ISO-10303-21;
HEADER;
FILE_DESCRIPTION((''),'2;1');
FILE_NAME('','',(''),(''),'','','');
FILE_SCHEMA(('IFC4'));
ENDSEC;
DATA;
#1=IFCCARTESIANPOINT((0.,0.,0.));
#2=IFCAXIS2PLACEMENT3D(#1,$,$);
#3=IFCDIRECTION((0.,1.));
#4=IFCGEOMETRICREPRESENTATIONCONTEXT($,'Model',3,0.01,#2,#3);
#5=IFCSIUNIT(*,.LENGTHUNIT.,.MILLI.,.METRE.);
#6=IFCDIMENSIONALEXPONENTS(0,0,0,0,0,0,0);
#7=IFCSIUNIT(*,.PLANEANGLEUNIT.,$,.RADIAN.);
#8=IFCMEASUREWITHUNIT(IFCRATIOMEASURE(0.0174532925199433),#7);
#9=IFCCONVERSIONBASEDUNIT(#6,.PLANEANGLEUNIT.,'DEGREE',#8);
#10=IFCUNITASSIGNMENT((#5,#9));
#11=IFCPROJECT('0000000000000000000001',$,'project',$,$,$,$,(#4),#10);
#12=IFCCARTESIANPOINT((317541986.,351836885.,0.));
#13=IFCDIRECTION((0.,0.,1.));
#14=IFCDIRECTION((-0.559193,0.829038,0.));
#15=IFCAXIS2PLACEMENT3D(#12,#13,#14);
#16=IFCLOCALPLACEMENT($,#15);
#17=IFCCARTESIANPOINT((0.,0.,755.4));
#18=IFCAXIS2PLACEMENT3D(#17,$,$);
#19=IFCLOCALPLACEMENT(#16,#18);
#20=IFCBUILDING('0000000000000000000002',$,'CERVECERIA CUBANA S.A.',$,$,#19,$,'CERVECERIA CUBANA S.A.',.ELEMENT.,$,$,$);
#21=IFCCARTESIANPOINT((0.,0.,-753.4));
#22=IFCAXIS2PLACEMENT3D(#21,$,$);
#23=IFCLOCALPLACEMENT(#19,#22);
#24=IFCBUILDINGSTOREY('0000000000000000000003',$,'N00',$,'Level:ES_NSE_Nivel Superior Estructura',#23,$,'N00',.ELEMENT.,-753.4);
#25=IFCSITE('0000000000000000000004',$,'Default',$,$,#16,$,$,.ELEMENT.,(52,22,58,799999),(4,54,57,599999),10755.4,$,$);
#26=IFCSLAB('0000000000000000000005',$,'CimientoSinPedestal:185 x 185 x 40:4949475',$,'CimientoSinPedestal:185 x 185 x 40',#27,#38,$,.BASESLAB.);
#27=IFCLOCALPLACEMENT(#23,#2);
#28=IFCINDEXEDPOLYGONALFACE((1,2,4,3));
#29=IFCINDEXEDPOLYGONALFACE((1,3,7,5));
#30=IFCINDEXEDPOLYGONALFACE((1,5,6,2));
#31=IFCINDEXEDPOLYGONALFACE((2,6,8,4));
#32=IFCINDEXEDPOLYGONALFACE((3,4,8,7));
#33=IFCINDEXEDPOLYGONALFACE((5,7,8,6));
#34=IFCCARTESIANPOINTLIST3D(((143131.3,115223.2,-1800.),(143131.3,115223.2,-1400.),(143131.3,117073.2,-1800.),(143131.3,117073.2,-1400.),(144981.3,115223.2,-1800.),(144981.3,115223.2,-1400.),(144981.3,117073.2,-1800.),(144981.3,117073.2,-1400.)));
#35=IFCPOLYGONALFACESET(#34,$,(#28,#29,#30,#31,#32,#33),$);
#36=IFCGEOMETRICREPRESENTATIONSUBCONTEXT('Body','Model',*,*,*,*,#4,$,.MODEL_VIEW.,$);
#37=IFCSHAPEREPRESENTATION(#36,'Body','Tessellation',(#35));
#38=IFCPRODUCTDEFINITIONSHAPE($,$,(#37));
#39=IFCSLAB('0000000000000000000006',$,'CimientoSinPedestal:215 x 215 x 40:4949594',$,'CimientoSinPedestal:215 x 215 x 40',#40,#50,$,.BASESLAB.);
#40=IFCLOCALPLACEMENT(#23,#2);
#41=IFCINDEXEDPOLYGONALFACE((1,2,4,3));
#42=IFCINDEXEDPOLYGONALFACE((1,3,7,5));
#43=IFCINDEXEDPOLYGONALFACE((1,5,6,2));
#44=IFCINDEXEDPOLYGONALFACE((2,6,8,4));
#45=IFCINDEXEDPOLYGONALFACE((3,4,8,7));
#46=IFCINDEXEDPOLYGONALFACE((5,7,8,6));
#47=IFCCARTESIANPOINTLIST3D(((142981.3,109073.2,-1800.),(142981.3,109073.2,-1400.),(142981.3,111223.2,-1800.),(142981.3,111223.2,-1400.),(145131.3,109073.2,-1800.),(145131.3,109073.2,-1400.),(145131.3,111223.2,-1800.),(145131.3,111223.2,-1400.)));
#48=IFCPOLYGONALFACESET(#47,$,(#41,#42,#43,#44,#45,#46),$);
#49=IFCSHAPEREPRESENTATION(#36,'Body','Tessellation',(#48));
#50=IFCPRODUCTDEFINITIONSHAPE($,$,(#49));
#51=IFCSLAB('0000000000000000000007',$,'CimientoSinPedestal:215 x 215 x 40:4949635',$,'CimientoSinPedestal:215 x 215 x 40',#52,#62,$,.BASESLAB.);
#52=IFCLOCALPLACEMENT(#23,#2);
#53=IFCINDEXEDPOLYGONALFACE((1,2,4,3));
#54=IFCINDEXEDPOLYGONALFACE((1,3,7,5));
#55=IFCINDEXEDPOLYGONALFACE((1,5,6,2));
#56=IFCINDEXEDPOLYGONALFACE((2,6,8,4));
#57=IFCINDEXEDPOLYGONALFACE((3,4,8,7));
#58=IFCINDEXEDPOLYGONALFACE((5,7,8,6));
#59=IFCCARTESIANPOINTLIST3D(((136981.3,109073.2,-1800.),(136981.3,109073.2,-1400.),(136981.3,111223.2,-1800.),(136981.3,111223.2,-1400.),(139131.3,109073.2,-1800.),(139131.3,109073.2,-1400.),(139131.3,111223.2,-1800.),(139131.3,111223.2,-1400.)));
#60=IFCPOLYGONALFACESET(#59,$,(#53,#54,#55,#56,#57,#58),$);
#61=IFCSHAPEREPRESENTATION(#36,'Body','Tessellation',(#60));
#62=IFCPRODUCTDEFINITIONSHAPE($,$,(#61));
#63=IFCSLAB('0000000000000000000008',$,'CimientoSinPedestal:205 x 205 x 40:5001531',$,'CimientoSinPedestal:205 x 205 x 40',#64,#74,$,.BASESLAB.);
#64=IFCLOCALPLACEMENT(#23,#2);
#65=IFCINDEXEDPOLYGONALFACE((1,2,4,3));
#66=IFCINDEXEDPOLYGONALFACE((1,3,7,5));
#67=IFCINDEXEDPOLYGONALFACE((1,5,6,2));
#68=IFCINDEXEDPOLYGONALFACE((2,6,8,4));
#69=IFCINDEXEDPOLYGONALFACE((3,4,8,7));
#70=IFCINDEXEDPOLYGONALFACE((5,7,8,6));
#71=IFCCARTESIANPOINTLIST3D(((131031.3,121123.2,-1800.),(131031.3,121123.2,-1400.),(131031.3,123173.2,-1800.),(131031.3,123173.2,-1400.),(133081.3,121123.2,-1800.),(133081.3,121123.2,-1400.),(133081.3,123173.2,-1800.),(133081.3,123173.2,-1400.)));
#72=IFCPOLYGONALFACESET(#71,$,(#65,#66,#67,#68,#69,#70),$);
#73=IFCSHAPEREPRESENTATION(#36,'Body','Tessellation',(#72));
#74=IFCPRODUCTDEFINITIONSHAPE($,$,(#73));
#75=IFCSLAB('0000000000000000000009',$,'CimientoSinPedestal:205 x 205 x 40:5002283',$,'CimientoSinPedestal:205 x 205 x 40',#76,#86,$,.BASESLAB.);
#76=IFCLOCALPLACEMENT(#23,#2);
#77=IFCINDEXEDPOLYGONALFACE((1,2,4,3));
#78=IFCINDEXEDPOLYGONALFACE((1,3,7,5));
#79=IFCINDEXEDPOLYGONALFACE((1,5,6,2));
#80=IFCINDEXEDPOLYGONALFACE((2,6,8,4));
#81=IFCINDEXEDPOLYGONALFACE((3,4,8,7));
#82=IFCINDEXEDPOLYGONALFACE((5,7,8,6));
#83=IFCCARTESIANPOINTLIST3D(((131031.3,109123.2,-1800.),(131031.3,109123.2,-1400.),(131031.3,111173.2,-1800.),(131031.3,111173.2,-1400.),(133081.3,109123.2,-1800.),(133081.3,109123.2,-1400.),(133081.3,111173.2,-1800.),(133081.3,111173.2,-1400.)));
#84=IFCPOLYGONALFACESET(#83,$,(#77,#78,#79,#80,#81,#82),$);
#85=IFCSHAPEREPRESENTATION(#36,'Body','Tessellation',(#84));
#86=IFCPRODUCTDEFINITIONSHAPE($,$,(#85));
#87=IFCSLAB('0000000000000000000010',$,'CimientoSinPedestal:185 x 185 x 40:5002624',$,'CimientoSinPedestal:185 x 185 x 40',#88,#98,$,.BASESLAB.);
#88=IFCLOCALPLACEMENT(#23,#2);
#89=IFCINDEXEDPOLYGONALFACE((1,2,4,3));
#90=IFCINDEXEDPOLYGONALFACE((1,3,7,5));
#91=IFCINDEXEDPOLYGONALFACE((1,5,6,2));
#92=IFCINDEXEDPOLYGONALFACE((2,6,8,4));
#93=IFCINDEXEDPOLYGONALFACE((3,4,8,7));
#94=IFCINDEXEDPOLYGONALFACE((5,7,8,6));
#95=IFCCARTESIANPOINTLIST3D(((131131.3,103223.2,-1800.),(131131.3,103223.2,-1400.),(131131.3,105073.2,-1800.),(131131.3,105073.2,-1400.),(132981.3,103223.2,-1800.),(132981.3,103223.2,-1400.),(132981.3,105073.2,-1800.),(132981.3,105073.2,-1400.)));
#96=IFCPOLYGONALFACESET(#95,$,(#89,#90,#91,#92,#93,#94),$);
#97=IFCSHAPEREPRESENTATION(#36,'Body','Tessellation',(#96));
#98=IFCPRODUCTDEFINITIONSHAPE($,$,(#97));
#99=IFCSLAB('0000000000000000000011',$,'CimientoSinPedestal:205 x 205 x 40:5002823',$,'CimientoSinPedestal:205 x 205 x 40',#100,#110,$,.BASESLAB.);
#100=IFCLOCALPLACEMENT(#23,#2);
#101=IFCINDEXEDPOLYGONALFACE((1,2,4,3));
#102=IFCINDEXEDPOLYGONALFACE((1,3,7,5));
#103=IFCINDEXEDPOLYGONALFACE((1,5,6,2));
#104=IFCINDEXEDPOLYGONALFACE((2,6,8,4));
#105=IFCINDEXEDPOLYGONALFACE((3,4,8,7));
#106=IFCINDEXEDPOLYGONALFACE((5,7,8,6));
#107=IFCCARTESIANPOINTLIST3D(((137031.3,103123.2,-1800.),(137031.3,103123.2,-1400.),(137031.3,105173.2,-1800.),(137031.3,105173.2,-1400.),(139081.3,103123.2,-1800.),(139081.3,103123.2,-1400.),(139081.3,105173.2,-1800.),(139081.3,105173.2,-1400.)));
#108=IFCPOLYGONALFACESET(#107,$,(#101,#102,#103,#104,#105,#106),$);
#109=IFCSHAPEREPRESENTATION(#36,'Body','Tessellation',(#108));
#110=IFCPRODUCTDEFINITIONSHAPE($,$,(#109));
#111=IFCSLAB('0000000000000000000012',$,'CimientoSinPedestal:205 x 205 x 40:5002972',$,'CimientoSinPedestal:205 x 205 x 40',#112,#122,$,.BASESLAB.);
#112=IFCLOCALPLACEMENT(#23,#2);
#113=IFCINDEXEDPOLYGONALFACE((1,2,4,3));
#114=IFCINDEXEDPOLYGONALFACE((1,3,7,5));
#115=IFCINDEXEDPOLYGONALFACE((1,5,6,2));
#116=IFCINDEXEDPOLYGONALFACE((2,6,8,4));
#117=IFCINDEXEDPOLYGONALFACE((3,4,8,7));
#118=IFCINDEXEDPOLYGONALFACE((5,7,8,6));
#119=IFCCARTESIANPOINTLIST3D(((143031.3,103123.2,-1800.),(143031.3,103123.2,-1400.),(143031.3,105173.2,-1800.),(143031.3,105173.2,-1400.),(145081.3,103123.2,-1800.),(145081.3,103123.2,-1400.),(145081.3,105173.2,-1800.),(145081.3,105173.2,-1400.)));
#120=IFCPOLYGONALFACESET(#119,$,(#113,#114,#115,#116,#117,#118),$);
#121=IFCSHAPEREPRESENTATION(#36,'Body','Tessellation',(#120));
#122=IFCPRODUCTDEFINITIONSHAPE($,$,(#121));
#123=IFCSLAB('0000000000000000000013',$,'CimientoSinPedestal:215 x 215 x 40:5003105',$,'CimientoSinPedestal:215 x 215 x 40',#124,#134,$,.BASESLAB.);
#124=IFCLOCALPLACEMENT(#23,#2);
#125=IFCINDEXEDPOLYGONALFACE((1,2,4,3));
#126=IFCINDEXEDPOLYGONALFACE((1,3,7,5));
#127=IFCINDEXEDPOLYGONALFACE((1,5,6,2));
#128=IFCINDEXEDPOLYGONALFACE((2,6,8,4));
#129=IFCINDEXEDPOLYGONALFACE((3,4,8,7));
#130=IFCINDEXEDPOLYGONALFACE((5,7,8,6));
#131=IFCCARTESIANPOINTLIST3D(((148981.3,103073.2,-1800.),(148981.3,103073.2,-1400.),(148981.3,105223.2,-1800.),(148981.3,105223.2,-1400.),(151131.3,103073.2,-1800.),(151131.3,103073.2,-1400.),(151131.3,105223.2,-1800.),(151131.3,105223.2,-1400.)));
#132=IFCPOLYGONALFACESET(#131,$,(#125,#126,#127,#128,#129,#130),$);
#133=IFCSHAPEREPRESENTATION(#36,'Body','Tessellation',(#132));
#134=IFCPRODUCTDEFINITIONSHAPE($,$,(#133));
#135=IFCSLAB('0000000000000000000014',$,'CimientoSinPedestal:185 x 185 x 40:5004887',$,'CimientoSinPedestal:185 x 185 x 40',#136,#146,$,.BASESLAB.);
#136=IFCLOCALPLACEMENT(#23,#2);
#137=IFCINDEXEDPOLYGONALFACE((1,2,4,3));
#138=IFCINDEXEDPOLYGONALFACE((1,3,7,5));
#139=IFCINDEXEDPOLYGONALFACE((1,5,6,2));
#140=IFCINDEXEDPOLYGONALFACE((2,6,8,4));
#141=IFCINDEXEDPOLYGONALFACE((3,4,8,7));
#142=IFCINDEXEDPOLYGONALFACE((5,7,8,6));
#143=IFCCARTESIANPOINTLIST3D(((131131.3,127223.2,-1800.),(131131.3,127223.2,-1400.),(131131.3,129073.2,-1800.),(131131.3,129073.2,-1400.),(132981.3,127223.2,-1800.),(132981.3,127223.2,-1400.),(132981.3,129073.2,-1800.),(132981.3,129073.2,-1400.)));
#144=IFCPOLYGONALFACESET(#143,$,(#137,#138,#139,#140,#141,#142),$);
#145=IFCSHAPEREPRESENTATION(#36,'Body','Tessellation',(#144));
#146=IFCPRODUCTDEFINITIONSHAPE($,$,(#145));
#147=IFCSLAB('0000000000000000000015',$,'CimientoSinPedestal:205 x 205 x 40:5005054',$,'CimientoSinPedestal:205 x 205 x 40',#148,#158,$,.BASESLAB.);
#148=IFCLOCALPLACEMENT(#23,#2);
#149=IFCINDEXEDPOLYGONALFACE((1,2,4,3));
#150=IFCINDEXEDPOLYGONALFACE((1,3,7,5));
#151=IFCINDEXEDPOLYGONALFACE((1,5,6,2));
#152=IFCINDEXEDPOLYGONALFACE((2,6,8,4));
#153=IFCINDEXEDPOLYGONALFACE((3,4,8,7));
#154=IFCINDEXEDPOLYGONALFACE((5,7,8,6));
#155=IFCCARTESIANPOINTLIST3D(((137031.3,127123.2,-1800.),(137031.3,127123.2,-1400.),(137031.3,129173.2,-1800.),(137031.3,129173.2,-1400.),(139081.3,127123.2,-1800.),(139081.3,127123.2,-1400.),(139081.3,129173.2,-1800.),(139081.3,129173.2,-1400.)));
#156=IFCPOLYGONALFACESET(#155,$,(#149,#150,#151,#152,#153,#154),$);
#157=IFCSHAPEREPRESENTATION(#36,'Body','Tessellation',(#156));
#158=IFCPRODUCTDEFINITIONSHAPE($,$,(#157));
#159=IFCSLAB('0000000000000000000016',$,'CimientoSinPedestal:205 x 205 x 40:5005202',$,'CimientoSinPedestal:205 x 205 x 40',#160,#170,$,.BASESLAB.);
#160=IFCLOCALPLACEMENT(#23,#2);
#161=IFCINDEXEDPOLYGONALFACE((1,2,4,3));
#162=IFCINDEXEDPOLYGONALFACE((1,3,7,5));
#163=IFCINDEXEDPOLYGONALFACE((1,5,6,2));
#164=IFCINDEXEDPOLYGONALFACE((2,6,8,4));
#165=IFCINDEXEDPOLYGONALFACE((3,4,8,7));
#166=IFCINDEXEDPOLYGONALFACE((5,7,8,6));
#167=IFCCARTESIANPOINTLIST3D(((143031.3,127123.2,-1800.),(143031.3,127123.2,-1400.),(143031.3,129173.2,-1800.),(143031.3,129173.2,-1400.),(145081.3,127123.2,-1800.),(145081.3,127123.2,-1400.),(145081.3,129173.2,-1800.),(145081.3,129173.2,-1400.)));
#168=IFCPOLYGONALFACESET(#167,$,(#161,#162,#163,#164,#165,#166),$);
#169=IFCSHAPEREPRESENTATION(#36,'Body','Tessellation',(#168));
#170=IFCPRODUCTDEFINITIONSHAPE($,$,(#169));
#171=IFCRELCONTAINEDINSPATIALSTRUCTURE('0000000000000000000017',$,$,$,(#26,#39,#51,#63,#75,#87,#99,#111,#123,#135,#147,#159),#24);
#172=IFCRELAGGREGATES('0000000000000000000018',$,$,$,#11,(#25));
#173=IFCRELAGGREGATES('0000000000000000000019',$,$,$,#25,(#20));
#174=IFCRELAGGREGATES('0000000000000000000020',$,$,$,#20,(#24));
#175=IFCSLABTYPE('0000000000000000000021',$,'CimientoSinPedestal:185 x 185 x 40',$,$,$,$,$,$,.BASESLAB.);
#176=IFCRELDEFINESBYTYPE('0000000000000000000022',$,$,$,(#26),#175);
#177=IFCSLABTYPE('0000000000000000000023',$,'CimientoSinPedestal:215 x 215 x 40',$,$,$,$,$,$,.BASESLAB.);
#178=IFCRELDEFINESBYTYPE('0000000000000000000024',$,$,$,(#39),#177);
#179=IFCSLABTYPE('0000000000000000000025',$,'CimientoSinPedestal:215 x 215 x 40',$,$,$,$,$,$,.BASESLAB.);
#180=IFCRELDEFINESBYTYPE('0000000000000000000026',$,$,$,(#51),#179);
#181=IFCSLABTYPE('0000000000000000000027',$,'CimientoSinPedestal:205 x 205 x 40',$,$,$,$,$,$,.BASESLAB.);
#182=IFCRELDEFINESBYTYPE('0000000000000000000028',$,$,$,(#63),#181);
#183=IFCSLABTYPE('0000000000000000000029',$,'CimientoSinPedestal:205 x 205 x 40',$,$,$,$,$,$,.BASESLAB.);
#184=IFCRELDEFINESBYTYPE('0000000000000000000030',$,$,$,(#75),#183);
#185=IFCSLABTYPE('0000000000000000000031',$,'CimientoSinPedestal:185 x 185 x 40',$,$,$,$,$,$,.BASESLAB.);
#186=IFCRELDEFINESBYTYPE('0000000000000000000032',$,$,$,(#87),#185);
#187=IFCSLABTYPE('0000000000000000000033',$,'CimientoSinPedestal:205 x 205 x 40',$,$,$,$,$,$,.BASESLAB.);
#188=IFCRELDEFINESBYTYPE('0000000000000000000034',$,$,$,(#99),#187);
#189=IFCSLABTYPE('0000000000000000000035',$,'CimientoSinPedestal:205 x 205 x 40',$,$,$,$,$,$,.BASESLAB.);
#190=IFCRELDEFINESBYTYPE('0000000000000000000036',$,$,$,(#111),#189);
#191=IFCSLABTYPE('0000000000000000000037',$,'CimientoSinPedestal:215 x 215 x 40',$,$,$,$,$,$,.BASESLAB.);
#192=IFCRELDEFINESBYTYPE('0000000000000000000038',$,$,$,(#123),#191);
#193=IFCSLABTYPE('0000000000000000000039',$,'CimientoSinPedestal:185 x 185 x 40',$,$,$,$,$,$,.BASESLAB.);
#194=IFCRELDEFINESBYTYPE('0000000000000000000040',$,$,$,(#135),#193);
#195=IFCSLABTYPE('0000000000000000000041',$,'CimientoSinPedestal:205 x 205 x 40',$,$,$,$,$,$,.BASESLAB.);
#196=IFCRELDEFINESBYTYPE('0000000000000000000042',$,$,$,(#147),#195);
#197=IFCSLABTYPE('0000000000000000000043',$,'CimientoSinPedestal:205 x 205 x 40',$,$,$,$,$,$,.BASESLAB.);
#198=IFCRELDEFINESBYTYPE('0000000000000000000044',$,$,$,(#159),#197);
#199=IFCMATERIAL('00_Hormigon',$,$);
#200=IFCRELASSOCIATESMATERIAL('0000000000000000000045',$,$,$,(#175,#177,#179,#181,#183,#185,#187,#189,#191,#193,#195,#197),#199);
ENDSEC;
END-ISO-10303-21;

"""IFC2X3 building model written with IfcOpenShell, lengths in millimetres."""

from ifc_helpers import new_model, entity, si_unit, converted_unit, direction, frame, frame_2d, origin, origin_2d_with_axis, place, context, subcontext, project, spatial, rectangle, extrude, material, type_object, element, save


model = new_model("IFC2X3")

# Units and contexts
model_context = context("Model", 3, precision=0.01, world=origin(), true_north=direction((0.0, 1.0)))
body_context = subcontext(model_context, "Body", "Model", "MODEL_VIEW")
ifc_project = project(units=[si_unit("LENGTHUNIT", "METRE", prefix="MILLI"), converted_unit("PLANEANGLEUNIT", "DEGREE", entity("IfcRatioMeasure", 0.0174532925199433), si_unit("PLANEANGLEUNIT", "RADIAN"), dimensions=[0, 0, 0, 0, 0, 0, 0])], contexts=[model_context])

# Site, building, storey
site_placement = place(None, frame((317541986.0, 351836885.0, 0.0), z_axis=(0.0, 0.0, 1.0), x_axis=(-0.559193, 0.829038, 0.0)))
site = spatial("IfcSite", under=ifc_project, at=site_placement, Name="Default", CompositionType="ELEMENT", RefLatitude=(52, 22, 58, 799999), RefLongitude=(4, 54, 57, 599999), RefElevation=10755.4)
building_placement = place(site_placement, frame((0.0, 0.0, 755.4)))
building = spatial("IfcBuilding", under=site, at=building_placement, Name="CERVECERIA CUBANA S.A.", LongName="CERVECERIA CUBANA S.A.", CompositionType="ELEMENT")
storey_placement = place(building_placement, frame((0.0, 0.0, -753.4)))
storey = spatial("IfcBuildingStorey", under=building, at=storey_placement, Name="N00", ObjectType="Level:ES_NSE_Nivel Superior Estructura", LongName="N00", CompositionType="ELEMENT", Elevation=-753.4)

# Slabs
ifc_material_1 = material(Name="00_Hormigon")
slab_type_1 = type_object("IfcSlabType", Name="CimientoSinPedestal:185 x 185 x 40", PredefinedType="BASESLAB", material=ifc_material_1)
slab_1_placement = place(storey_placement, origin())
element("IfcSlab", 1, at=slab_1_placement, inside=storey, type_object=slab_type_1, Name="CimientoSinPedestal:185 x 185 x 40:4949475", ObjectType="CimientoSinPedestal:185 x 185 x 40", PredefinedType="BASESLAB", context=body_context, shape_type="SweptSolid", body=[
    extrude(rectangle(XDim=1850.0, YDim=1850.0, at=frame_2d((0.0, 0.0), x_axis=(1.0, 0.0))), frame((144056.3, 116148.2, -1800.0), z_axis=(0.0, 0.0, 1.0), x_axis=(-1.0, 0.0, 0.0)), (0.0, 0.0, 1.0), 400.0),
])
slab_type_2 = type_object("IfcSlabType", Name="CimientoSinPedestal:215 x 215 x 40", PredefinedType="BASESLAB", material=ifc_material_1)
slab_2_placement = place(storey_placement, origin())
element("IfcSlab", 2, at=slab_2_placement, inside=storey, type_object=slab_type_2, Name="CimientoSinPedestal:215 x 215 x 40:4949594", ObjectType="CimientoSinPedestal:215 x 215 x 40", PredefinedType="BASESLAB", context=body_context, shape_type="SweptSolid", body=[
    extrude(rectangle(XDim=2150.0, YDim=2150.0, at=frame_2d((0.0, 0.0), x_axis=(1.0, 0.0))), frame((144056.3, 110148.2, -1800.0), z_axis=(0.0, 0.0, 1.0), x_axis=(-1.0, 0.0, 0.0)), (0.0, 0.0, 1.0), 400.0),
])
slab_type_3 = type_object("IfcSlabType", Name="CimientoSinPedestal:215 x 215 x 40", PredefinedType="BASESLAB", material=ifc_material_1)
slab_3_placement = place(storey_placement, origin())
element("IfcSlab", 3, at=slab_3_placement, inside=storey, type_object=slab_type_3, Name="CimientoSinPedestal:215 x 215 x 40:4949635", ObjectType="CimientoSinPedestal:215 x 215 x 40", PredefinedType="BASESLAB", context=body_context, shape_type="SweptSolid", body=[
    extrude(rectangle(XDim=2150.0, YDim=2150.0, at=origin_2d_with_axis()), frame((138056.3, 110148.2, -1800.0), z_axis=(0.0, 0.0, 1.0), x_axis=(-1.0, 0.0, 0.0)), (0.0, 0.0, 1.0), 400.0),
])
slab_type_4 = type_object("IfcSlabType", Name="CimientoSinPedestal:205 x 205 x 40", PredefinedType="BASESLAB", material=ifc_material_1)
slab_4_placement = place(storey_placement, origin())
element("IfcSlab", 4, at=slab_4_placement, inside=storey, type_object=slab_type_4, Name="CimientoSinPedestal:205 x 205 x 40:5001531", ObjectType="CimientoSinPedestal:205 x 205 x 40", PredefinedType="BASESLAB", context=body_context, shape_type="SweptSolid", body=[
    extrude(rectangle(XDim=2050.0, YDim=2050.0, at=frame_2d((0.0, 0.0), x_axis=(1.0, 0.0))), frame((132056.3, 122148.2, -1800.0), z_axis=(0.0, 0.0, 1.0), x_axis=(-1.0, 0.0, 0.0)), (0.0, 0.0, 1.0), 400.0),
])
slab_type_5 = type_object("IfcSlabType", Name="CimientoSinPedestal:205 x 205 x 40", PredefinedType="BASESLAB", material=ifc_material_1)
slab_5_placement = place(storey_placement, origin())
element("IfcSlab", 5, at=slab_5_placement, inside=storey, type_object=slab_type_5, Name="CimientoSinPedestal:205 x 205 x 40:5002283", ObjectType="CimientoSinPedestal:205 x 205 x 40", PredefinedType="BASESLAB", context=body_context, shape_type="SweptSolid", body=[
    extrude(rectangle(XDim=2050.0, YDim=2050.0, at=frame_2d((0.0, 0.0), x_axis=(1.0, 0.0))), frame((132056.3, 110148.2, -1800.0), z_axis=(0.0, 0.0, 1.0), x_axis=(-1.0, 0.0, 0.0)), (0.0, 0.0, 1.0), 400.0),
])
slab_type_6 = type_object("IfcSlabType", Name="CimientoSinPedestal:185 x 185 x 40", PredefinedType="BASESLAB", material=ifc_material_1)
slab_6_placement = place(storey_placement, origin())
element("IfcSlab", 6, at=slab_6_placement, inside=storey, type_object=slab_type_6, Name="CimientoSinPedestal:185 x 185 x 40:5002624", ObjectType="CimientoSinPedestal:185 x 185 x 40", PredefinedType="BASESLAB", context=body_context, shape_type="SweptSolid", body=[
    extrude(rectangle(XDim=1850.0, YDim=1850.0, at=frame_2d((0.0, 0.0), x_axis=(1.0, 0.0))), frame((132056.3, 104148.2, -1800.0), z_axis=(0.0, 0.0, 1.0), x_axis=(-1.0, 0.0, 0.0)), (0.0, 0.0, 1.0), 400.0),
])
slab_type_7 = type_object("IfcSlabType", Name="CimientoSinPedestal:205 x 205 x 40", PredefinedType="BASESLAB", material=ifc_material_1)
slab_7_placement = place(storey_placement, origin())
element("IfcSlab", 7, at=slab_7_placement, inside=storey, type_object=slab_type_7, Name="CimientoSinPedestal:205 x 205 x 40:5002823", ObjectType="CimientoSinPedestal:205 x 205 x 40", PredefinedType="BASESLAB", context=body_context, shape_type="SweptSolid", body=[
    extrude(rectangle(XDim=2050.0, YDim=2050.0, at=frame_2d((0.0, 0.0), x_axis=(1.0, 0.0))), frame((138056.3, 104148.2, -1800.0), z_axis=(0.0, 0.0, 1.0), x_axis=(-1.0, 0.0, 0.0)), (0.0, 0.0, 1.0), 400.0),
])
slab_type_8 = type_object("IfcSlabType", Name="CimientoSinPedestal:205 x 205 x 40", PredefinedType="BASESLAB", material=ifc_material_1)
slab_8_placement = place(storey_placement, origin())
element("IfcSlab", 8, at=slab_8_placement, inside=storey, type_object=slab_type_8, Name="CimientoSinPedestal:205 x 205 x 40:5002972", ObjectType="CimientoSinPedestal:205 x 205 x 40", PredefinedType="BASESLAB", context=body_context, shape_type="SweptSolid", body=[
    extrude(rectangle(XDim=2050.0, YDim=2050.0, at=frame_2d((0.0, 0.0), x_axis=(1.0, 0.0))), frame((144056.3, 104148.2, -1800.0), z_axis=(0.0, 0.0, 1.0), x_axis=(-1.0, 0.0, 0.0)), (0.0, 0.0, 1.0), 400.0),
])
slab_type_9 = type_object("IfcSlabType", Name="CimientoSinPedestal:215 x 215 x 40", PredefinedType="BASESLAB", material=ifc_material_1)
slab_9_placement = place(storey_placement, origin())
element("IfcSlab", 9, at=slab_9_placement, inside=storey, type_object=slab_type_9, Name="CimientoSinPedestal:215 x 215 x 40:5003105", ObjectType="CimientoSinPedestal:215 x 215 x 40", PredefinedType="BASESLAB", context=body_context, shape_type="SweptSolid", body=[
    extrude(rectangle(XDim=2150.0, YDim=2150.0, at=origin_2d_with_axis()), frame((150056.3, 104148.2, -1800.0), z_axis=(0.0, 0.0, 1.0), x_axis=(-1.0, 0.0, 0.0)), (0.0, 0.0, 1.0), 400.0),
])
slab_type_10 = type_object("IfcSlabType", Name="CimientoSinPedestal:185 x 185 x 40", PredefinedType="BASESLAB", material=ifc_material_1)
slab_10_placement = place(storey_placement, origin())
element("IfcSlab", 10, at=slab_10_placement, inside=storey, type_object=slab_type_10, Name="CimientoSinPedestal:185 x 185 x 40:5004887", ObjectType="CimientoSinPedestal:185 x 185 x 40", PredefinedType="BASESLAB", context=body_context, shape_type="SweptSolid", body=[
    extrude(rectangle(XDim=1850.0, YDim=1850.0, at=origin_2d_with_axis()), frame((132056.3, 128148.2, -1800.0), z_axis=(0.0, 0.0, 1.0), x_axis=(-1.0, 0.0, 0.0)), (0.0, 0.0, 1.0), 400.0),
])
slab_type_11 = type_object("IfcSlabType", Name="CimientoSinPedestal:205 x 205 x 40", PredefinedType="BASESLAB", material=ifc_material_1)
slab_11_placement = place(storey_placement, origin())
element("IfcSlab", 11, at=slab_11_placement, inside=storey, type_object=slab_type_11, Name="CimientoSinPedestal:205 x 205 x 40:5005054", ObjectType="CimientoSinPedestal:205 x 205 x 40", PredefinedType="BASESLAB", context=body_context, shape_type="SweptSolid", body=[
    extrude(rectangle(XDim=2050.0, YDim=2050.0, at=frame_2d((0.0, 0.0), x_axis=(1.0, 0.0))), frame((138056.3, 128148.2, -1800.0), z_axis=(0.0, 0.0, 1.0), x_axis=(-1.0, 0.0, 0.0)), (0.0, 0.0, 1.0), 400.0),
])
slab_type_12 = type_object("IfcSlabType", Name="CimientoSinPedestal:205 x 205 x 40", PredefinedType="BASESLAB", material=ifc_material_1)
slab_12_placement = place(storey_placement, origin())
element("IfcSlab", 12, at=slab_12_placement, inside=storey, type_object=slab_type_12, Name="CimientoSinPedestal:205 x 205 x 40:5005202", ObjectType="CimientoSinPedestal:205 x 205 x 40", PredefinedType="BASESLAB", context=body_context, shape_type="SweptSolid", body=[
    extrude(rectangle(XDim=2050.0, YDim=2050.0, at=frame_2d((0.0, 0.0), x_axis=(1.0, 0.0))), frame((144056.3, 128148.2, -1800.0), z_axis=(0.0, 0.0, 1.0), x_axis=(-1.0, 0.0, 0.0)), (0.0, 0.0, 1.0), 400.0),
])

save(model, "model.ifc")
